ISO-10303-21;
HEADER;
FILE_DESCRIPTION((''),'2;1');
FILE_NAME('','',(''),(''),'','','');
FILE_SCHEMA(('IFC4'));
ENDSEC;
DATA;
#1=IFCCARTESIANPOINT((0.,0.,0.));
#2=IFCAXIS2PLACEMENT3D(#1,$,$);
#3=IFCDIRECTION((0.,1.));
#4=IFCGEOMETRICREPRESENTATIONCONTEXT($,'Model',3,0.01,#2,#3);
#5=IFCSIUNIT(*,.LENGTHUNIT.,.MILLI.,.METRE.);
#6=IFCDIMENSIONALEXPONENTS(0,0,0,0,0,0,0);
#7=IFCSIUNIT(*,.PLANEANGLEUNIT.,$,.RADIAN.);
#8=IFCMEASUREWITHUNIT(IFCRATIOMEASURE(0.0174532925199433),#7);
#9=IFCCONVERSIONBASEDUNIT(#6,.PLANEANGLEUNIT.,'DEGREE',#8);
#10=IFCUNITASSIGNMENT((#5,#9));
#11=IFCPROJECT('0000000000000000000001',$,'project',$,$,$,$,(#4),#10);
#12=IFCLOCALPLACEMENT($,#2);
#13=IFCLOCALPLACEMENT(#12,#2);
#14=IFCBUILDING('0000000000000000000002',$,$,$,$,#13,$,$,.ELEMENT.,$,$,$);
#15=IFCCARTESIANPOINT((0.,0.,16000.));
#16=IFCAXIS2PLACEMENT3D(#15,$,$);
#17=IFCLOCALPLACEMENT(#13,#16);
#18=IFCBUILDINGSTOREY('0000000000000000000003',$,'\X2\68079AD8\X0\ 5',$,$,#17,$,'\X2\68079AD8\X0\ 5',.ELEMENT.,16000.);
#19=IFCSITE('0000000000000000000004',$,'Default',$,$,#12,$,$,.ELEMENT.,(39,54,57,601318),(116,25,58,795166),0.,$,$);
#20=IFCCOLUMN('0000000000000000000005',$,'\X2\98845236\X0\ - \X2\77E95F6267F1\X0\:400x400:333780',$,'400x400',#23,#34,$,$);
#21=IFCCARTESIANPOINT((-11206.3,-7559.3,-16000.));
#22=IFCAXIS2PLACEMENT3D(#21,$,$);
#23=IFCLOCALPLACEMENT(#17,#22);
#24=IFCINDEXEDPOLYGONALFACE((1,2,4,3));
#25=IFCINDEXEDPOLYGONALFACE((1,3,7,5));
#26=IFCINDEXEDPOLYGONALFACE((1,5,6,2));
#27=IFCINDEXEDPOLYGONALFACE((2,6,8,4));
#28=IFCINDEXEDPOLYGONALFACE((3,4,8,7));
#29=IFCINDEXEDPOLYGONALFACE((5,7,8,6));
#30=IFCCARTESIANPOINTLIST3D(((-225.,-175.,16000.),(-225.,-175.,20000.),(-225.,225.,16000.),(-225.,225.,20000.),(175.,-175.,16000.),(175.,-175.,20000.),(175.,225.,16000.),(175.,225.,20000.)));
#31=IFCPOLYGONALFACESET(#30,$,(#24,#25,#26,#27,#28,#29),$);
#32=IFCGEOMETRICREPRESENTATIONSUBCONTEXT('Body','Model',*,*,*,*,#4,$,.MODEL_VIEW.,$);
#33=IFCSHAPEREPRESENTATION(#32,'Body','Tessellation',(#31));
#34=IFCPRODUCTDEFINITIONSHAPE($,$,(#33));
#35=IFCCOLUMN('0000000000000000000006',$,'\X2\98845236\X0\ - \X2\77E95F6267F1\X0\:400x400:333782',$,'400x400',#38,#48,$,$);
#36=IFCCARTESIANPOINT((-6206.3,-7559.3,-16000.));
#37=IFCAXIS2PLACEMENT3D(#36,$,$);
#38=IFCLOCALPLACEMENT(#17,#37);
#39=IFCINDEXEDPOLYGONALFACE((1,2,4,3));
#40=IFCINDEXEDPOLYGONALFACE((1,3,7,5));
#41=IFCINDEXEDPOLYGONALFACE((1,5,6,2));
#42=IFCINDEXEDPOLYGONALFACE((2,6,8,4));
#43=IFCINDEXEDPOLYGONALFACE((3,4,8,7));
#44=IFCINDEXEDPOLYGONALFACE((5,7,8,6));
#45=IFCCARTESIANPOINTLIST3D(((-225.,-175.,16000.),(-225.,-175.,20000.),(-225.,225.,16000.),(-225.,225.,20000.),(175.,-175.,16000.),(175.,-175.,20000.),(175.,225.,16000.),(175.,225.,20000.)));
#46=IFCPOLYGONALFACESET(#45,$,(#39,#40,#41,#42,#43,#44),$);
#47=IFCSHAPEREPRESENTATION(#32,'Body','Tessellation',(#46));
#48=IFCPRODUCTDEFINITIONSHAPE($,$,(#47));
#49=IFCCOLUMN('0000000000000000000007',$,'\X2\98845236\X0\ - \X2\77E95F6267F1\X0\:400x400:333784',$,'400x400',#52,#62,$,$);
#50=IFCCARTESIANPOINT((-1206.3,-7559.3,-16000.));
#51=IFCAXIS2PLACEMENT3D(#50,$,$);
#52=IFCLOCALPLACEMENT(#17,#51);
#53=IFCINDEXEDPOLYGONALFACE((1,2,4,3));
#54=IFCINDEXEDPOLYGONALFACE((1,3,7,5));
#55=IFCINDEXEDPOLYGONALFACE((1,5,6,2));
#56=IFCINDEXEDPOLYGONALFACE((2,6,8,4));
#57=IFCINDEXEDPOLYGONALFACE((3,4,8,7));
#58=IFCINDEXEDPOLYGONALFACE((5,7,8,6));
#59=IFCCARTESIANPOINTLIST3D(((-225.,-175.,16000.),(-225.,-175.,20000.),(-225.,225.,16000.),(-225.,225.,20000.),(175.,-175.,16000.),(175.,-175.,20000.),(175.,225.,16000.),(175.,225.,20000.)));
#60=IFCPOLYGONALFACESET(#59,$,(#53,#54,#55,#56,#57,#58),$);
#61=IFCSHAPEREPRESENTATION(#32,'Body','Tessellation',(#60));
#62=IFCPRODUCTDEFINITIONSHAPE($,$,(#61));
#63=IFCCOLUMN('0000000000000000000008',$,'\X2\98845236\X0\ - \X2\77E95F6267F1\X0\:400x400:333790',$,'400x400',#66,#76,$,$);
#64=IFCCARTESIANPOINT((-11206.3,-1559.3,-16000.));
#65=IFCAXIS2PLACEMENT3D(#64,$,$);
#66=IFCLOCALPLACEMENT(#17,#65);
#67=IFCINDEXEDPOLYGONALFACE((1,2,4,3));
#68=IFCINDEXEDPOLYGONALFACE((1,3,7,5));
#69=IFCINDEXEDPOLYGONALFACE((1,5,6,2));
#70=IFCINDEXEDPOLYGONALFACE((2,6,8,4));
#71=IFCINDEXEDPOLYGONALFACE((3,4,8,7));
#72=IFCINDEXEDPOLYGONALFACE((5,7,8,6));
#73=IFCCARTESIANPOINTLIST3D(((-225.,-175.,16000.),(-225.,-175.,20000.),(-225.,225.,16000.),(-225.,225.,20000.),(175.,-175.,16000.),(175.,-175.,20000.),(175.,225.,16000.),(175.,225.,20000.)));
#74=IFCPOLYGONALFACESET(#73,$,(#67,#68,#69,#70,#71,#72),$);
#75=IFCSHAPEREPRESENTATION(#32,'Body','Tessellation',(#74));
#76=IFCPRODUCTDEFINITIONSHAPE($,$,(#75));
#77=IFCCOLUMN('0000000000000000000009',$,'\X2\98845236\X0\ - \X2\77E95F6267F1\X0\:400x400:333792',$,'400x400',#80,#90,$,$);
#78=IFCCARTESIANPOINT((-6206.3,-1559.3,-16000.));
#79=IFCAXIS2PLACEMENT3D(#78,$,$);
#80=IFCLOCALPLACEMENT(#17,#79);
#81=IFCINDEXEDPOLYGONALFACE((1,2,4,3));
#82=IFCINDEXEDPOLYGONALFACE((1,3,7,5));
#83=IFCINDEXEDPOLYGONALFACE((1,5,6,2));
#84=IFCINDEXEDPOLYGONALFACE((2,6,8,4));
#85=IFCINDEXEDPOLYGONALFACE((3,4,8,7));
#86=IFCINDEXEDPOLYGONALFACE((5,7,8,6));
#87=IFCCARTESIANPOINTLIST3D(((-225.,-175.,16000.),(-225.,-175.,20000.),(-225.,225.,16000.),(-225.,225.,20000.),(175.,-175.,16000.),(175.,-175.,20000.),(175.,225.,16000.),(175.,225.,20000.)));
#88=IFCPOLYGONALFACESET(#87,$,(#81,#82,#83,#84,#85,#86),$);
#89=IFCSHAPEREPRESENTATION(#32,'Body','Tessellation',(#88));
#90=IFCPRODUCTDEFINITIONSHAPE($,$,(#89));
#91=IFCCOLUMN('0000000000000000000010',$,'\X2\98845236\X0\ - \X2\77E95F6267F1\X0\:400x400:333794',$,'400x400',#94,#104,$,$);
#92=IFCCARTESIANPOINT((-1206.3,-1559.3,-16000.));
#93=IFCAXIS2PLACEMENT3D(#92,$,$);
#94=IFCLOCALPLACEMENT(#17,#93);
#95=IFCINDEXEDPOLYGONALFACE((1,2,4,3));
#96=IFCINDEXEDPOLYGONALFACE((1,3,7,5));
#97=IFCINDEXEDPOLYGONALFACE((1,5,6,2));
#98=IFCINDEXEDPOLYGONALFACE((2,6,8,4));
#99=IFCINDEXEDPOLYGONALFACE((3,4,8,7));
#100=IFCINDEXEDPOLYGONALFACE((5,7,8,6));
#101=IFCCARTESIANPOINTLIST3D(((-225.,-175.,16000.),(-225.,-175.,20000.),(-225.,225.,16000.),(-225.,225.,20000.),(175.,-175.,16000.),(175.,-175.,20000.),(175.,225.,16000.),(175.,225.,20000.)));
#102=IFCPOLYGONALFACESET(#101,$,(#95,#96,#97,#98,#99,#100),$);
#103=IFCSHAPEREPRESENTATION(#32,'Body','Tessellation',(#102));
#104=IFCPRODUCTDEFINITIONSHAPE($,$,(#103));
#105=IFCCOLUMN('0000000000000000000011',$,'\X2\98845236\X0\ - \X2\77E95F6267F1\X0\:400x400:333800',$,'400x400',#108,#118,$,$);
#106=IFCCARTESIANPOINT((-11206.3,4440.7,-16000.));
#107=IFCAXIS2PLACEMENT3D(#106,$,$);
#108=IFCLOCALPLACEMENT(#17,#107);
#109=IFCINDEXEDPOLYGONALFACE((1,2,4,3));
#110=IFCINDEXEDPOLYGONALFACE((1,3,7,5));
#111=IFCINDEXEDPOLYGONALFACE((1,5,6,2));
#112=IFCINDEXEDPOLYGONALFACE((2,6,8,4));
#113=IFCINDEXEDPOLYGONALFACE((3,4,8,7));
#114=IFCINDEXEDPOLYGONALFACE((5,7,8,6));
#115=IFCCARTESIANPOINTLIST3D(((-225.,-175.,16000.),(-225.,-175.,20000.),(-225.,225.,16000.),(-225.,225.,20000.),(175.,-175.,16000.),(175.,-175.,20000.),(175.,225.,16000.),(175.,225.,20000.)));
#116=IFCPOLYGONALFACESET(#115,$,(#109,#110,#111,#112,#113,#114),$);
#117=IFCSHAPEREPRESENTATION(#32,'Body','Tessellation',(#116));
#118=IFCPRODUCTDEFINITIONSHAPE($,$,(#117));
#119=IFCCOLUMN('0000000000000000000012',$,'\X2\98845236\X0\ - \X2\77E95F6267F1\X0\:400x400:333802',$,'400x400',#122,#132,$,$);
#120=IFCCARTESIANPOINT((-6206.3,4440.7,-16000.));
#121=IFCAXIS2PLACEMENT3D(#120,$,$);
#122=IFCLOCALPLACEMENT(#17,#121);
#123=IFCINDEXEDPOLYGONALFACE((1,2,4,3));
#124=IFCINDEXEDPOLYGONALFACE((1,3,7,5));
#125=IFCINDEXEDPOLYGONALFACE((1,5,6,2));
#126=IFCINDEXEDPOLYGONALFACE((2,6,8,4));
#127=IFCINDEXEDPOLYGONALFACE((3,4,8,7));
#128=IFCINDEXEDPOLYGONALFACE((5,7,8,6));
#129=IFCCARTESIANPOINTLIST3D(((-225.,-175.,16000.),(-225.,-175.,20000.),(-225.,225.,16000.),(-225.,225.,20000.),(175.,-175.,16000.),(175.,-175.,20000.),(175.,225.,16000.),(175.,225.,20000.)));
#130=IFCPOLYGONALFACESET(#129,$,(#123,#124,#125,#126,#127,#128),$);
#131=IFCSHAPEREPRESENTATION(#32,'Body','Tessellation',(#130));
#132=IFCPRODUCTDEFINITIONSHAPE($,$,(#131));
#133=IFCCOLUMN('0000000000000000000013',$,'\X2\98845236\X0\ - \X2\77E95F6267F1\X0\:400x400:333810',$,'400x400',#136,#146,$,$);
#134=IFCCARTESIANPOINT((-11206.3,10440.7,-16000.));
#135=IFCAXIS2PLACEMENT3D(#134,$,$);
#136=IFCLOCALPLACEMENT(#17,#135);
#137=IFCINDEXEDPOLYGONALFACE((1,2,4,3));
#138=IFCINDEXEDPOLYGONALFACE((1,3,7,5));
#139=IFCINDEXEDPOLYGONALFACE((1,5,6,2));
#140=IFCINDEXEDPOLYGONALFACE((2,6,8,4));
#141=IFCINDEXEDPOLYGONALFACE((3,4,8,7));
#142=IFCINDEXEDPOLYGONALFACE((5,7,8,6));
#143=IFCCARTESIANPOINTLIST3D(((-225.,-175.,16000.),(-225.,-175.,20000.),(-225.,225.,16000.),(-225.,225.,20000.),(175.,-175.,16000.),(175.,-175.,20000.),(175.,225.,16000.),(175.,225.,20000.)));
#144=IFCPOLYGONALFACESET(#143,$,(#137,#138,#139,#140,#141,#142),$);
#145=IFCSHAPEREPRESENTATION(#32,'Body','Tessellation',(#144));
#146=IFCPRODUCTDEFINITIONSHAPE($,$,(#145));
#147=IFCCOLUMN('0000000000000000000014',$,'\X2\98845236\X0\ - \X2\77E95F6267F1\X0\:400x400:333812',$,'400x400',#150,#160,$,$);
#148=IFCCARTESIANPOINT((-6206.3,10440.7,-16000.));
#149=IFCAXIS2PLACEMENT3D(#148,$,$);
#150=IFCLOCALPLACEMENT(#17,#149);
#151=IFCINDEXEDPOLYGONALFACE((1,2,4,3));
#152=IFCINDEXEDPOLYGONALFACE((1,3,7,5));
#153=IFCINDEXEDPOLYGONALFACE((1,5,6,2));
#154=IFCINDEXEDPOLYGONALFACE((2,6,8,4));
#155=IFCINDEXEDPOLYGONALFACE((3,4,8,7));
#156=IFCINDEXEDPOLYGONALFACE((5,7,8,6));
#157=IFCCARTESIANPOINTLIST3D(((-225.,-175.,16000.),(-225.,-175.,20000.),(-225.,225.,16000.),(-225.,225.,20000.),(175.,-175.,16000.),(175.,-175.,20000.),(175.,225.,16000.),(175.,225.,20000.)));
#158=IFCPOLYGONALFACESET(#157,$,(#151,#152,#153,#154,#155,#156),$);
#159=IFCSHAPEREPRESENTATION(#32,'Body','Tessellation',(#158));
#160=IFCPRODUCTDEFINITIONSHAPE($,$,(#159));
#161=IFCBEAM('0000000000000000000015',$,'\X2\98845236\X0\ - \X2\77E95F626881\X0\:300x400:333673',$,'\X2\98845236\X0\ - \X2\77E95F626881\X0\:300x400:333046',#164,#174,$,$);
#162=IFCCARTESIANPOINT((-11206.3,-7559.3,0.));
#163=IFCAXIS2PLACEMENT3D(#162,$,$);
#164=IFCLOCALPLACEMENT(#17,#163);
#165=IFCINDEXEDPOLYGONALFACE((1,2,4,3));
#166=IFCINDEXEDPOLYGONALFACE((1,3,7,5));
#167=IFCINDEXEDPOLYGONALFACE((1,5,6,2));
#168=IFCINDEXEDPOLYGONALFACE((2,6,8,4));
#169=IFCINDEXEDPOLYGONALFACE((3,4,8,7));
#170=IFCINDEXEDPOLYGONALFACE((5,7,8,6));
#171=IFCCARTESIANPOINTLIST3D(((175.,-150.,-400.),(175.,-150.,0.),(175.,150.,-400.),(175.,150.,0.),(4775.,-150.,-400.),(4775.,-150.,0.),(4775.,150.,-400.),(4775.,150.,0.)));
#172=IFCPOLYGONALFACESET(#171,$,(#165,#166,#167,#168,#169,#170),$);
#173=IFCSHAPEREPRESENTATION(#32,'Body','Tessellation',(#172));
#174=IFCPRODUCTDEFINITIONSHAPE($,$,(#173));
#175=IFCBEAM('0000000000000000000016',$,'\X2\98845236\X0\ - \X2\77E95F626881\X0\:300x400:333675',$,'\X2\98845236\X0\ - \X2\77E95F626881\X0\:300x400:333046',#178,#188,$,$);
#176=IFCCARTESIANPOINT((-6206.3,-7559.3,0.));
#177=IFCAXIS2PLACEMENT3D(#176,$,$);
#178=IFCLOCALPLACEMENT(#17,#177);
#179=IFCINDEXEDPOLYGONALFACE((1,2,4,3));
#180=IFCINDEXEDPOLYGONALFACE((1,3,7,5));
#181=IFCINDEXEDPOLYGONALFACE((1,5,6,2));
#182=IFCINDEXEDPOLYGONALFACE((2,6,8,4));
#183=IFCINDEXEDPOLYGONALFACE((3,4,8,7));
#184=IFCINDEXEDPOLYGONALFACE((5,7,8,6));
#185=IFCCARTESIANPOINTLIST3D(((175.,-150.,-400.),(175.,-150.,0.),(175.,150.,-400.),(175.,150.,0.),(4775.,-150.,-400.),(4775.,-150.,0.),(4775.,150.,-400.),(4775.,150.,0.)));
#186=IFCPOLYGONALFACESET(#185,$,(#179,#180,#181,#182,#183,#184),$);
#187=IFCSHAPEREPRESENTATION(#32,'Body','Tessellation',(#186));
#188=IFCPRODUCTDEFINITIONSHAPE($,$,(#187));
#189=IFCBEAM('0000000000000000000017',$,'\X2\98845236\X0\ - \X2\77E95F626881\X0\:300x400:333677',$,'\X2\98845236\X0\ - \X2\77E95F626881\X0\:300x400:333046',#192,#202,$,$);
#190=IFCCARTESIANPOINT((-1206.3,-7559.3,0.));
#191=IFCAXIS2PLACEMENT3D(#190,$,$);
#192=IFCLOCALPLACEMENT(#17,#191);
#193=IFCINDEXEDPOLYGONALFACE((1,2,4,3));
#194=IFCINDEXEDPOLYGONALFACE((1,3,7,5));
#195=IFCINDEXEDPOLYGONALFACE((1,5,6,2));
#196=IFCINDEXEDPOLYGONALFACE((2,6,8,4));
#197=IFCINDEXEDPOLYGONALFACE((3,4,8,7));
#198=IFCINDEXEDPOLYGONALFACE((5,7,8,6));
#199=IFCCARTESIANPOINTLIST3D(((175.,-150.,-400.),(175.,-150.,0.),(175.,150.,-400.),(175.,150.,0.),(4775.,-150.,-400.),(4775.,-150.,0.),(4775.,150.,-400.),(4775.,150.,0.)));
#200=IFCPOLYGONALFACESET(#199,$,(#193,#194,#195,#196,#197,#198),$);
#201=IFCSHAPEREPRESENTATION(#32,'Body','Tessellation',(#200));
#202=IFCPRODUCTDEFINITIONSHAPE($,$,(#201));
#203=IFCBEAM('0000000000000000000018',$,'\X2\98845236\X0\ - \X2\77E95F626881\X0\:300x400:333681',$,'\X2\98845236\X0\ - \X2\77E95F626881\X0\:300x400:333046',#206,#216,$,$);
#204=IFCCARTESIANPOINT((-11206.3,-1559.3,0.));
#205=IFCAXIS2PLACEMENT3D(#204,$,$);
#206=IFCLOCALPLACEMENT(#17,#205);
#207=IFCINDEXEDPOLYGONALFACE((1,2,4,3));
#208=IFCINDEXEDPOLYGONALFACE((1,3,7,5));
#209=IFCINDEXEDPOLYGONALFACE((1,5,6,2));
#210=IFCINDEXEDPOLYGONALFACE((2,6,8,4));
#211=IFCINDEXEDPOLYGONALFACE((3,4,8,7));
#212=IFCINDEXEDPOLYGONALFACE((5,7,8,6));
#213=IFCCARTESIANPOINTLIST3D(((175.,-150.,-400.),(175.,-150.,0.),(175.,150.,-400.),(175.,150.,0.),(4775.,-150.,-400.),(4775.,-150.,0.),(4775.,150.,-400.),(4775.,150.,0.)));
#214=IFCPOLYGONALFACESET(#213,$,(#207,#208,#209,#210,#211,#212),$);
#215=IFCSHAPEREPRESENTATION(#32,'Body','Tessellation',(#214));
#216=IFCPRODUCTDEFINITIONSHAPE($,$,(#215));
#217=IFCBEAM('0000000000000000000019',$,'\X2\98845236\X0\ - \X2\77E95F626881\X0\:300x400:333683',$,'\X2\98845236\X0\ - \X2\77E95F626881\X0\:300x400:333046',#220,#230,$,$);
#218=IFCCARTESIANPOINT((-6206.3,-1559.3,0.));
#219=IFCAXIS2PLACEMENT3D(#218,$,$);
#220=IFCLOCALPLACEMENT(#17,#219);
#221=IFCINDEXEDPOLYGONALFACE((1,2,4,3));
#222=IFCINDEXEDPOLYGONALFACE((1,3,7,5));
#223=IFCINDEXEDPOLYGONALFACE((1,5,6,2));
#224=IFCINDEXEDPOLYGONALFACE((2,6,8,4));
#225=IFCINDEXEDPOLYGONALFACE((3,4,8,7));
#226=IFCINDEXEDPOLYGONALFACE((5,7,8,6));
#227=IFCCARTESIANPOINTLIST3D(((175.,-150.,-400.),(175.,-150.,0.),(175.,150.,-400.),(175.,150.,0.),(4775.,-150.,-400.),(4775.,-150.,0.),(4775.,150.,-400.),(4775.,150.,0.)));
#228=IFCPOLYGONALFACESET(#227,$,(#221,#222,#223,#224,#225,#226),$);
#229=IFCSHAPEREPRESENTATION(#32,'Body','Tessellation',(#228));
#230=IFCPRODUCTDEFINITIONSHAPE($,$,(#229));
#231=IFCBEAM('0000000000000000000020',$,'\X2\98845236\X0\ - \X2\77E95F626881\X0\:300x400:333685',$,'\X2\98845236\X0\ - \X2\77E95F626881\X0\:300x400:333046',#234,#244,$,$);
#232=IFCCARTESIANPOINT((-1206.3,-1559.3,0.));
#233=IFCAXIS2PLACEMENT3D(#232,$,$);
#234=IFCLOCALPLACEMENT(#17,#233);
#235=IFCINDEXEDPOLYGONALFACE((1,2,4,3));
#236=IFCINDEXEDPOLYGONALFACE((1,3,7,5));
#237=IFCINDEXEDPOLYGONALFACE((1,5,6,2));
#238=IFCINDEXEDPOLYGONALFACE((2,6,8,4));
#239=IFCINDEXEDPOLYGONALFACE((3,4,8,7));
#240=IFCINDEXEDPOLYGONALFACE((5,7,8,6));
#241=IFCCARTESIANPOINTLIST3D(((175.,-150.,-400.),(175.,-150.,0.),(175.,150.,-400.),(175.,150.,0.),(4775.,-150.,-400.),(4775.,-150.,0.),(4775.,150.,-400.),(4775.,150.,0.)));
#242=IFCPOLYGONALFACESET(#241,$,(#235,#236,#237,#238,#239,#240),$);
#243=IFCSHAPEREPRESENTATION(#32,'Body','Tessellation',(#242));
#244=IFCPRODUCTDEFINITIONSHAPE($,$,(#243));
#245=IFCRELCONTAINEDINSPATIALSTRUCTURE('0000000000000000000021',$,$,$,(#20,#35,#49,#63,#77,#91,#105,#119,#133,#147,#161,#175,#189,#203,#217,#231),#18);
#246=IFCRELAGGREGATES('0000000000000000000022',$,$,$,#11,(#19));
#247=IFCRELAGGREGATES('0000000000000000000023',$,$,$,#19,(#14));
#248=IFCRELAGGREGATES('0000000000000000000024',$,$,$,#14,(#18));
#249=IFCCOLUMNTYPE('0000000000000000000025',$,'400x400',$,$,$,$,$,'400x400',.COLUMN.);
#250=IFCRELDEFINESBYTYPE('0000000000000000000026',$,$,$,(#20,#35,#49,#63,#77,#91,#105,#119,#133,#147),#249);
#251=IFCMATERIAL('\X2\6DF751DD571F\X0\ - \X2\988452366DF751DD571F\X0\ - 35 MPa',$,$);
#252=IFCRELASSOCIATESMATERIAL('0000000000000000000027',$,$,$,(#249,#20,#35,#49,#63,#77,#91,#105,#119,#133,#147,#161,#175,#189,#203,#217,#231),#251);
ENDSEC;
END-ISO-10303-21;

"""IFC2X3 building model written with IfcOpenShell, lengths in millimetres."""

from ifc_helpers import new_model, entity, si_unit, converted_unit, direction, frame, frame_2d, origin, place, context, subcontext, project, spatial, rectangle, extrude, source, transform, mapped, material, type_object, type_shapes, element, save


model = new_model("IFC2X3")

# Units and contexts
model_context = context("Model", 3, precision=0.01, world=origin(), true_north=direction((0.0, 1.0)))
body_context = subcontext(model_context, "Body", "Model", "MODEL_VIEW")
ifc_project = project(units=[si_unit("LENGTHUNIT", "METRE", prefix="MILLI"), converted_unit("PLANEANGLEUNIT", "DEGREE", entity("IfcRatioMeasure", 0.0174532925199433), si_unit("PLANEANGLEUNIT", "RADIAN"), dimensions=[0, 0, 0, 0, 0, 0, 0])], contexts=[model_context])

# Site, building, storey
site_placement = place(None, origin())
site = spatial("IfcSite", under=ifc_project, at=site_placement, Name="Default", CompositionType="ELEMENT", RefLatitude=(39, 54, 57, 601318), RefLongitude=(116, 25, 58, 795166), RefElevation=0.0)
building_placement = place(site_placement, origin())
building = spatial("IfcBuilding", under=site, at=building_placement, CompositionType="ELEMENT")
storey_placement = place(building_placement, frame((0.0, 0.0, 16000.0)))
storey = spatial("IfcBuildingStorey", under=building, at=storey_placement, Name="标高 5", LongName="标高 5", CompositionType="ELEMENT", Elevation=16000.0)

# Columns
ifc_material = material(Name="混凝土 - 预制混凝土 - 35 MPa")
column_type = type_object("IfcColumnType", Name="400x400", ElementType="400x400", PredefinedType="COLUMN", material=ifc_material)
shared_shape = source(origin(), body_context, "Body", "SweptSolid", [
    extrude(rectangle(XDim=400.0, YDim=400.0, at=frame_2d((0.0, 0.0), x_axis=(1.0, 0.0))), frame((-25.0, 25.0, 16000.0)), (0.0, 0.0, 1.0), 4000.0),
])
type_shapes(column_type, [shared_shape])
for number, where, name in (
    (1, (-11206.3, -7559.3, -16000.0), "预制 - 矩形柱:400x400:333780"),
    (2, (-6206.3, -7559.3, -16000.0), "预制 - 矩形柱:400x400:333782"),
    (3, (-1206.3, -7559.3, -16000.0), "预制 - 矩形柱:400x400:333784"),
    (4, (-11206.3, -1559.3, -16000.0), "预制 - 矩形柱:400x400:333790"),
    (5, (-6206.3, -1559.3, -16000.0), "预制 - 矩形柱:400x400:333792"),
    (6, (-1206.3, -1559.3, -16000.0), "预制 - 矩形柱:400x400:333794"),
    (7, (-11206.3, 4440.7, -16000.0), "预制 - 矩形柱:400x400:333800"),
    (8, (-6206.3, 4440.7, -16000.0), "预制 - 矩形柱:400x400:333802"),
    (9, (-11206.3, 10440.7, -16000.0), "预制 - 矩形柱:400x400:333810"),
    (10, (-6206.3, 10440.7, -16000.0), "预制 - 矩形柱:400x400:333812"),
):
    element("IfcColumn", number, at=place(storey_placement, frame(where)), inside=storey, type_object=column_type, material=ifc_material, Name=name, ObjectType="400x400", context=body_context, shape_type="MappedRepresentation", body=[
        mapped(shared_shape, transform((0.0, 0.0, 0.0), scale=1.0)),
    ])

# Beams
for number, where, name in (
    (11, (-11206.3, -7559.3, 0.0), "预制 - 矩形梁:300x400:333673"),
    (12, (-6206.3, -7559.3, 0.0), "预制 - 矩形梁:300x400:333675"),
):
    element("IfcBeam", number, at=place(storey_placement, frame(where)), inside=storey, material=ifc_material, Name=name, ObjectType="预制 - 矩形梁:300x400:333046", context=body_context, shape_type="SweptSolid", body=[
        extrude(rectangle(XDim=400.0, YDim=300.0, at=frame_2d((0.0, 0.0), x_axis=(1.0, 0.0))), frame((175.0, 0.0, -200.0), z_axis=(1.0, 0.0, 0.0), x_axis=(0.0, 0.0, -1.0)), (0.0, 0.0, 1.0), 4600.0),
    ])
beam_1_placement = place(storey_placement, frame((-1206.3, -7559.3, 0.0)))
element("IfcBeam", 13, at=beam_1_placement, inside=storey, material=ifc_material, Name="预制 - 矩形梁:300x400:333677", ObjectType="预制 - 矩形梁:300x400:333046", context=body_context, shape_type="SweptSolid", body=[
    extrude(rectangle(XDim=400.0, YDim=300.0, at=frame_2d((0.0, 0.0), x_axis=(1.0, 0.0))), frame((175.0, 0.0, -200.0), z_axis=(1.0, 0.0, 0.0), x_axis=(0.0, 0.0, -1.0)), (0.0, 0.0, 1.0), 4600.0),
])
for number, where, name in (
    (14, (-11206.3, -1559.3, 0.0), "预制 - 矩形梁:300x400:333681"),
    (15, (-6206.3, -1559.3, 0.0), "预制 - 矩形梁:300x400:333683"),
    (16, (-1206.3, -1559.3, 0.0), "预制 - 矩形梁:300x400:333685"),
):
    element("IfcBeam", number, at=place(storey_placement, frame(where)), inside=storey, material=ifc_material, Name=name, ObjectType="预制 - 矩形梁:300x400:333046", context=body_context, shape_type="SweptSolid", body=[
        extrude(rectangle(XDim=400.0, YDim=300.0, at=frame_2d((0.0, 0.0), x_axis=(1.0, 0.0))), frame((175.0, 0.0, -200.0), z_axis=(1.0, 0.0, 0.0), x_axis=(0.0, 0.0, -1.0)), (0.0, 0.0, 1.0), 4600.0),
    ])

save(model, "model.ifc")
